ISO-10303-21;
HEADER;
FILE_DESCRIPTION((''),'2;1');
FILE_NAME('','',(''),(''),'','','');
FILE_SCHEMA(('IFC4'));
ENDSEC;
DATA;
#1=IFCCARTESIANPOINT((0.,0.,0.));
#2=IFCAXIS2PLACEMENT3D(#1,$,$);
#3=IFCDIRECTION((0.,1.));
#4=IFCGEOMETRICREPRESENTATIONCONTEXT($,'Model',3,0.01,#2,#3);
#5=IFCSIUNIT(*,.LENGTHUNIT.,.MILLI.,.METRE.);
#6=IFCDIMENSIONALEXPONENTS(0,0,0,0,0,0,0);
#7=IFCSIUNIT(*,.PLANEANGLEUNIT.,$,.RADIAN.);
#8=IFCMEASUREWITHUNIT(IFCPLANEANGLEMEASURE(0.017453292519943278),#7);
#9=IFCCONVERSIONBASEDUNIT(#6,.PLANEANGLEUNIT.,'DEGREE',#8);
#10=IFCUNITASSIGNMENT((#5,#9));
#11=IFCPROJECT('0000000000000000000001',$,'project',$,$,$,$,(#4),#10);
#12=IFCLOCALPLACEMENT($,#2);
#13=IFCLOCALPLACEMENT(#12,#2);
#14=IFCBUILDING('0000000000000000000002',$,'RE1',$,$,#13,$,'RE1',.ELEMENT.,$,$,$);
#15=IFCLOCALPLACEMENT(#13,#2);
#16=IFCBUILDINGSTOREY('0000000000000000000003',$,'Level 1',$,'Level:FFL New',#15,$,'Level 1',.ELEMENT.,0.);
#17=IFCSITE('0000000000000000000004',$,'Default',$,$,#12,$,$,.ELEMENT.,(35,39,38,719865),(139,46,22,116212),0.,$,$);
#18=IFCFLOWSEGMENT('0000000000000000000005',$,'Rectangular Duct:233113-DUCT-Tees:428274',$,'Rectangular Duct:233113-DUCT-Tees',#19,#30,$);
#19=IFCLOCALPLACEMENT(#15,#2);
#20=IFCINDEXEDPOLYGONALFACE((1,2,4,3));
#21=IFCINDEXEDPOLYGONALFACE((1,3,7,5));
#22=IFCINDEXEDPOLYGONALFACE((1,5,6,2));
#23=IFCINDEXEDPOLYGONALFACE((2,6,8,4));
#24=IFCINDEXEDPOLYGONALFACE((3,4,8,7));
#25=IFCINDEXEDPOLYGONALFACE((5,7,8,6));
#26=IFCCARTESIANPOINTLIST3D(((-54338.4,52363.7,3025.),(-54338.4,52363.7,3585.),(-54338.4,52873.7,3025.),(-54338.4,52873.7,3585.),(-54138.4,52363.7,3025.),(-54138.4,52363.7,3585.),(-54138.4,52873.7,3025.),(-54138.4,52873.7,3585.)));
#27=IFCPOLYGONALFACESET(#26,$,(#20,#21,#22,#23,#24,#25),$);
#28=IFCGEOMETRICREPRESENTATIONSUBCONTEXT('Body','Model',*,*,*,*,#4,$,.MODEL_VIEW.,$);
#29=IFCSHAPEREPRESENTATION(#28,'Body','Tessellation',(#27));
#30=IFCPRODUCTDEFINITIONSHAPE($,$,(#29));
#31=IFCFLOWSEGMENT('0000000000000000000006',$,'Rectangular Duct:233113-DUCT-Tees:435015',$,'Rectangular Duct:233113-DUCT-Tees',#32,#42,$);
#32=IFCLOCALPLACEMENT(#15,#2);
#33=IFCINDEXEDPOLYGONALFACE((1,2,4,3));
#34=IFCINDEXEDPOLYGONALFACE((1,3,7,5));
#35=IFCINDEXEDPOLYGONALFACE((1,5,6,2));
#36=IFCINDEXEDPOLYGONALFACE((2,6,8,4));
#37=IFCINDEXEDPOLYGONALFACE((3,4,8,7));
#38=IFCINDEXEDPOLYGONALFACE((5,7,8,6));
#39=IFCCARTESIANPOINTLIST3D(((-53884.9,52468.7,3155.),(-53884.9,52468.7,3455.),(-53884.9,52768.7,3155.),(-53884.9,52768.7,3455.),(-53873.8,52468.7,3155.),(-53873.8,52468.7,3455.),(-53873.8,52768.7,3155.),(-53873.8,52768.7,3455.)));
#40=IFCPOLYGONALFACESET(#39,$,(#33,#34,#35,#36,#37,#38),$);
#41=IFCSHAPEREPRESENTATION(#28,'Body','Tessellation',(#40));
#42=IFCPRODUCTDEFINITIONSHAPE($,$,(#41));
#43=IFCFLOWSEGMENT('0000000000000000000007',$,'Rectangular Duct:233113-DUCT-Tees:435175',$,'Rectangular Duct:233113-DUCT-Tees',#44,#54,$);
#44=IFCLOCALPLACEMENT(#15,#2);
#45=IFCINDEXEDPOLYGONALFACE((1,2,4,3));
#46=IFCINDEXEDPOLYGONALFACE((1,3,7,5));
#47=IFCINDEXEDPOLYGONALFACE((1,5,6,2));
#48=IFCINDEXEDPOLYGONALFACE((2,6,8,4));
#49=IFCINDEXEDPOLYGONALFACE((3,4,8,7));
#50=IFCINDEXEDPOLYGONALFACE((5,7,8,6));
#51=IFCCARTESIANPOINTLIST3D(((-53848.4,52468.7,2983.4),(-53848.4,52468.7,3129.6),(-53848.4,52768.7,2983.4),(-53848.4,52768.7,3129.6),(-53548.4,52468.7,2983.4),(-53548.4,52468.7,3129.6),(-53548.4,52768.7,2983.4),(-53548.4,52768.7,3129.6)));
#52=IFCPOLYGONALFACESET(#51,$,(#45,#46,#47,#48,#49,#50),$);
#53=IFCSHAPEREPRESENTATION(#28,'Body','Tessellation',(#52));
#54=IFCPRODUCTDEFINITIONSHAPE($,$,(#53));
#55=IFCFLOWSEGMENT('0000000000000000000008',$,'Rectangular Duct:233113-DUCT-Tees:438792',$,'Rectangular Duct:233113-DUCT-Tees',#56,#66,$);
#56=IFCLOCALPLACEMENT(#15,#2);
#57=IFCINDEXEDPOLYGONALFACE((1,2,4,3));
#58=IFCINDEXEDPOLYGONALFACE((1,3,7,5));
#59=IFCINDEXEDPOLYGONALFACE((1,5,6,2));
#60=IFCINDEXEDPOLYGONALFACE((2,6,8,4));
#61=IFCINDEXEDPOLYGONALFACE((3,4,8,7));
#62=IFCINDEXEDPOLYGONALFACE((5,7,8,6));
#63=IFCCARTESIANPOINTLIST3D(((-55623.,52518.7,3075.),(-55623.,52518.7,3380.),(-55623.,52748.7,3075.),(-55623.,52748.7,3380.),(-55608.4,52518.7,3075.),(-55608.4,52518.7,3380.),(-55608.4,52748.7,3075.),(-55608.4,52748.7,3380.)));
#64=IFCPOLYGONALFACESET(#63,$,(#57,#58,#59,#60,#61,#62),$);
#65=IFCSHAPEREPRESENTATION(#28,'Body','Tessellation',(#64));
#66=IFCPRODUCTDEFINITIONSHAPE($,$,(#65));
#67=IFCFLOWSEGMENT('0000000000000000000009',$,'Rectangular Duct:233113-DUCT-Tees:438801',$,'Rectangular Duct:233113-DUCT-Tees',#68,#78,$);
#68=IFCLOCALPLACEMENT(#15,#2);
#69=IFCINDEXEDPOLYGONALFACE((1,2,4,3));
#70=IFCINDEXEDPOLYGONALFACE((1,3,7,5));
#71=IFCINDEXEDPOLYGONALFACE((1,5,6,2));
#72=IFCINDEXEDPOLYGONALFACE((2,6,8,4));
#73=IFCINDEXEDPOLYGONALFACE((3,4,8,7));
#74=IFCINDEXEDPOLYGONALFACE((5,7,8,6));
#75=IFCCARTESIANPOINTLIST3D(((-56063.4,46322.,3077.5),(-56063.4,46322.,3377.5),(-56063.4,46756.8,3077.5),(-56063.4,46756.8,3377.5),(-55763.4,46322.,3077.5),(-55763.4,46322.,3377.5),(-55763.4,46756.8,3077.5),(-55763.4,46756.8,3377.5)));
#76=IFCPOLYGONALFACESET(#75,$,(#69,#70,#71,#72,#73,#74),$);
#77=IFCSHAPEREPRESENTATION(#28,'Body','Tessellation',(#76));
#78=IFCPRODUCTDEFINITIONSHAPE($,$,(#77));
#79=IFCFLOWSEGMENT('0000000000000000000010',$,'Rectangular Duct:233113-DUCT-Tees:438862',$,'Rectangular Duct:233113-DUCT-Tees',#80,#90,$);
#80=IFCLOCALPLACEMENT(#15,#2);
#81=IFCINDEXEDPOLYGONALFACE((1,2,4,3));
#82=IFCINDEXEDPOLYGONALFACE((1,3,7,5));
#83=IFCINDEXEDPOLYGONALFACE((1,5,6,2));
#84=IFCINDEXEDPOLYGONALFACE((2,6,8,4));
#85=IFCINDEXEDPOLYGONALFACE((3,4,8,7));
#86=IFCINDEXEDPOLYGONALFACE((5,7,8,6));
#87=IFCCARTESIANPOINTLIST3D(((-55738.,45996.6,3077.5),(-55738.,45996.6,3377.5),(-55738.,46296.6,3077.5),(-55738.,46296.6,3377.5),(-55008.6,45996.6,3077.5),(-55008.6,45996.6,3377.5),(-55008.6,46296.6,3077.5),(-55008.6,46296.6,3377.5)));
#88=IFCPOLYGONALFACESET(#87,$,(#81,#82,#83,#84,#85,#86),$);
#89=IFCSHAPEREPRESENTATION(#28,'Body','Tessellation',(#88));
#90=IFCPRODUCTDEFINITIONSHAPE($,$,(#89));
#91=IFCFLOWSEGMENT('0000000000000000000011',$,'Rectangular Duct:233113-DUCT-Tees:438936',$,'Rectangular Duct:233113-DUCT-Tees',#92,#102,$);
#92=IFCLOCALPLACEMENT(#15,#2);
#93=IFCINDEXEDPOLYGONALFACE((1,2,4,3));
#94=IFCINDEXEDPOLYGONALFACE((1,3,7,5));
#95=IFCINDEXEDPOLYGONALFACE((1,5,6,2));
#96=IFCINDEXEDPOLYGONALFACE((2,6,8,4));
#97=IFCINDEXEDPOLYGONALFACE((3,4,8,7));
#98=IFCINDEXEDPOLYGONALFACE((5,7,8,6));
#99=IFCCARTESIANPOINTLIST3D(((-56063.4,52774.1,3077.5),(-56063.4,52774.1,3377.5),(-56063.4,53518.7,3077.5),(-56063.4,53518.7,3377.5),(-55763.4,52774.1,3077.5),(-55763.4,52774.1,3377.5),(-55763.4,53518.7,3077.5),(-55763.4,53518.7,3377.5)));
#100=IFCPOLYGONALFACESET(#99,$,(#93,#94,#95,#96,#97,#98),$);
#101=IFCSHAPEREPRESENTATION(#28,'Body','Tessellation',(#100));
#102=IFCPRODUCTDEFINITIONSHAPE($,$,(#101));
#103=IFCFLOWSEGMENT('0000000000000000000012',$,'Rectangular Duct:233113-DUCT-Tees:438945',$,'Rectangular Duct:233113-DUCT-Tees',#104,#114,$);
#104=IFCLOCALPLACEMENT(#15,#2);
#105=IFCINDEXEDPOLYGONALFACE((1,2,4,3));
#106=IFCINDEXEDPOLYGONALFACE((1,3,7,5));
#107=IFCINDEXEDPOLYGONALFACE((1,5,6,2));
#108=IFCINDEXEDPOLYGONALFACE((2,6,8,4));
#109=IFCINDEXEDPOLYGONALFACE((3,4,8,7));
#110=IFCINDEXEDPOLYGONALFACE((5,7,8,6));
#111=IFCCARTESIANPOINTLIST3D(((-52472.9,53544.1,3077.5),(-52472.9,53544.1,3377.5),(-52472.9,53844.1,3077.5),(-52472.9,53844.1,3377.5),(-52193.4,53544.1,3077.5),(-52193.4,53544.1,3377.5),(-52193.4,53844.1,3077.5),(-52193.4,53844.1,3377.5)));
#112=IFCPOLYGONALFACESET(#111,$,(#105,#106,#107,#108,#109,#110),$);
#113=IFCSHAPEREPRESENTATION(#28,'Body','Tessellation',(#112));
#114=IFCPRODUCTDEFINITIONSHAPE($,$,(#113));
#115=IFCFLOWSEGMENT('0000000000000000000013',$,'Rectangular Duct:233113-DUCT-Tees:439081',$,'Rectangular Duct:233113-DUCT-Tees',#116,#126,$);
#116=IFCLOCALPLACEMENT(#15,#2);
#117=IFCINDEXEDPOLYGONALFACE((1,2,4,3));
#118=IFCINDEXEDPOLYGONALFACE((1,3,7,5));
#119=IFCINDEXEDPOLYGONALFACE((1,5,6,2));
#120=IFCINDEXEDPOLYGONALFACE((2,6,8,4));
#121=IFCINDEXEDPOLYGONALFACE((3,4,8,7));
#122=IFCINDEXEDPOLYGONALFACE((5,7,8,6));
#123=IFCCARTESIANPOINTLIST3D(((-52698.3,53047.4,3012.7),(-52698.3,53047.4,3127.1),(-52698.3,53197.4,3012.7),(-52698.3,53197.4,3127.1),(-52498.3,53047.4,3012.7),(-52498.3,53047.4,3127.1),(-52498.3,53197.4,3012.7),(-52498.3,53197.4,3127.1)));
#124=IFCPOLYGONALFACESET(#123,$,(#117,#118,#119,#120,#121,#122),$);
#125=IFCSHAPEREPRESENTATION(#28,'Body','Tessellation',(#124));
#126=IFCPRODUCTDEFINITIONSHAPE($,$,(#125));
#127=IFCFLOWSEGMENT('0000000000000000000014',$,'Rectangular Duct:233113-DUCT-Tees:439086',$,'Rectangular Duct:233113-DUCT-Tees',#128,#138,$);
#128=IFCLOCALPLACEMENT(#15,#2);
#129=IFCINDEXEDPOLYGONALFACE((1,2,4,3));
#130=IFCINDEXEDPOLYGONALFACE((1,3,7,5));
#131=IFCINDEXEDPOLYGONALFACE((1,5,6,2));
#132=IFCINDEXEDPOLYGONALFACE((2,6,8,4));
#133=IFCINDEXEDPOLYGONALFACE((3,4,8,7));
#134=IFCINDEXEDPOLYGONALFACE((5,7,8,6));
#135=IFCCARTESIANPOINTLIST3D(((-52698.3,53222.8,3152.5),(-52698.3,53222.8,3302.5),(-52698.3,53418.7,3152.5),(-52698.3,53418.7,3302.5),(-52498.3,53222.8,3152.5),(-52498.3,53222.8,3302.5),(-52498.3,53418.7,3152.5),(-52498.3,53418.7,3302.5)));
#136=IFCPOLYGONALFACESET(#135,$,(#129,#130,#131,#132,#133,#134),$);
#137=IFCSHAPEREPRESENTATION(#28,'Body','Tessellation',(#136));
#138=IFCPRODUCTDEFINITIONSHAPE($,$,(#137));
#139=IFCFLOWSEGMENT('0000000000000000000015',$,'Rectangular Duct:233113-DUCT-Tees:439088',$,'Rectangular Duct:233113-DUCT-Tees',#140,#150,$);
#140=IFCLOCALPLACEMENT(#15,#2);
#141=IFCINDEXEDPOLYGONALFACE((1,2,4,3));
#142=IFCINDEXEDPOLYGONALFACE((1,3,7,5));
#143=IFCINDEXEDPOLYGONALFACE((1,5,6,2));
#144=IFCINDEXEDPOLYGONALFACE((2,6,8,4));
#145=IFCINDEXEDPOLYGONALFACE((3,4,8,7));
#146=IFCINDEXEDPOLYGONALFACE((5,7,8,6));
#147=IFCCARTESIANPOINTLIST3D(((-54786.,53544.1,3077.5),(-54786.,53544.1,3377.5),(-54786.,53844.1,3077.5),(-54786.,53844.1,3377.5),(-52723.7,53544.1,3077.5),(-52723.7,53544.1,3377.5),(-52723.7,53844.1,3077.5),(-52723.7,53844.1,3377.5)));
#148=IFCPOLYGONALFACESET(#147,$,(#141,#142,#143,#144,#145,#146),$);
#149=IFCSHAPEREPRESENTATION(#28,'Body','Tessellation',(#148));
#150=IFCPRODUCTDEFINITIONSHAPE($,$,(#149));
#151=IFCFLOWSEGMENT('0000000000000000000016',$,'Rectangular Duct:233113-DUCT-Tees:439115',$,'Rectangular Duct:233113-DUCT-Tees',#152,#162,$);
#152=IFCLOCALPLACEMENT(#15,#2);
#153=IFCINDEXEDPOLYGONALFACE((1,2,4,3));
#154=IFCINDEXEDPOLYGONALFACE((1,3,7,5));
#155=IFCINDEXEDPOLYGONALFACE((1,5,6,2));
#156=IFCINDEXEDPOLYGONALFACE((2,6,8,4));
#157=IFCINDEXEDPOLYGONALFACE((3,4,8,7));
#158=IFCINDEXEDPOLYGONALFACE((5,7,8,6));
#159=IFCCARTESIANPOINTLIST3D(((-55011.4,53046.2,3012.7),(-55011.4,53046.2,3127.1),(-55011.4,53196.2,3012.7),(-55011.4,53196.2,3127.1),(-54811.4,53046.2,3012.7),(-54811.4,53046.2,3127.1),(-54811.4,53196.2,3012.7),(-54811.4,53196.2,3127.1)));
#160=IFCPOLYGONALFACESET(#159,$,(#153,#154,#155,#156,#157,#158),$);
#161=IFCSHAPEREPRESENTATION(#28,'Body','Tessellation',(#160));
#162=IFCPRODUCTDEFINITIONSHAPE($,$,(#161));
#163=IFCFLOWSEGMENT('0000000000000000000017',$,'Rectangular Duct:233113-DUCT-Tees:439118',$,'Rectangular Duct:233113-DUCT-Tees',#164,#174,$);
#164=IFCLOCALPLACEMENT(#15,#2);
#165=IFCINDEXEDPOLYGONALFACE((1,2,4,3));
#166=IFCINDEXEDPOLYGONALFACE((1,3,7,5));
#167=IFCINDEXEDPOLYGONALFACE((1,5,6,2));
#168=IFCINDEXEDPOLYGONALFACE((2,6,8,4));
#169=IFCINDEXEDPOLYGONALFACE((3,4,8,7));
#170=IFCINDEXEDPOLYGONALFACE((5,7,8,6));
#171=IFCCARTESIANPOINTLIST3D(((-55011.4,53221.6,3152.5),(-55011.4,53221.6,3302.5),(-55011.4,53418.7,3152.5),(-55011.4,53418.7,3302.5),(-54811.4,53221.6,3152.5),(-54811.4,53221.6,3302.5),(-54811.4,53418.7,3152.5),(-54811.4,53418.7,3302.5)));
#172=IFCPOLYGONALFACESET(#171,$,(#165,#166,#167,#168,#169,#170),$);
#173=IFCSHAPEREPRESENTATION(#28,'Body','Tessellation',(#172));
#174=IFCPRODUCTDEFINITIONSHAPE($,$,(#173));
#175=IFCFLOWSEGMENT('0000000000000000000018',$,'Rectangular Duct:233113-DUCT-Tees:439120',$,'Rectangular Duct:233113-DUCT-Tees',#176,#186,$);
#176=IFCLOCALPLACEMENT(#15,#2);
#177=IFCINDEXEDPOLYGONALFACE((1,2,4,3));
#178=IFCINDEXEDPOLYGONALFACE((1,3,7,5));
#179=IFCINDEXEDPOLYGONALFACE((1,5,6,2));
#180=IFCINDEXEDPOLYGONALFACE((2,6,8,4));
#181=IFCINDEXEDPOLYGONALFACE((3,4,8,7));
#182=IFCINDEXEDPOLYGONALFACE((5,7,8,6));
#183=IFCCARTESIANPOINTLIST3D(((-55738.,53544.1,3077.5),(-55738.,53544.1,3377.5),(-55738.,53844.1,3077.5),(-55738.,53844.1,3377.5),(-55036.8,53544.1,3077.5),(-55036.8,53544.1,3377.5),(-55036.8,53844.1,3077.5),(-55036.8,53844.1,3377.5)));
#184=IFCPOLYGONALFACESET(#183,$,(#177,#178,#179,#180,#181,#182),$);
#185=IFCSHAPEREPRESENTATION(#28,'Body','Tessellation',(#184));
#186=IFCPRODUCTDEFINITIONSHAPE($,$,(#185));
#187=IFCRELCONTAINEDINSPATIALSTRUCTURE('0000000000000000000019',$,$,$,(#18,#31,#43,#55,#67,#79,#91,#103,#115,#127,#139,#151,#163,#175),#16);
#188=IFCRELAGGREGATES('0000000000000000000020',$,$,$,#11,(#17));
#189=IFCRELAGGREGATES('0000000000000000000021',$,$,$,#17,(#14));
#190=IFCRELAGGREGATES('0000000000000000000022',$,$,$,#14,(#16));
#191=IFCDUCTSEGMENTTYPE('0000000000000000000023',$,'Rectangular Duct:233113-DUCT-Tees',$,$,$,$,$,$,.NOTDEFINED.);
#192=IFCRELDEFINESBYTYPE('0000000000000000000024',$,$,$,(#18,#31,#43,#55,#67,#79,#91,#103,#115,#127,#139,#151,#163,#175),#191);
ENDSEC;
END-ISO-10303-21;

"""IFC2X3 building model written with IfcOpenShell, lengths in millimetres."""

from ifc_helpers import new_model, entity, si_unit, converted_unit, direction, frame, frame_2d, origin, origin_2d_with_axis, place, context, subcontext, project, spatial, rectangle, extrude, type_object, element, save


model = new_model("IFC2X3")

# Units and contexts
model_context = context("Model", 3, precision=0.01, world=origin(), true_north=direction((0.0, 1.0)))
body_context = subcontext(model_context, "Body", "Model", "MODEL_VIEW")
ifc_project = project(units=[si_unit("LENGTHUNIT", "METRE", prefix="MILLI"), converted_unit("PLANEANGLEUNIT", "DEGREE", entity("IfcPlaneAngleMeasure", 0.017453292519943278), si_unit("PLANEANGLEUNIT", "RADIAN"), dimensions=[0, 0, 0, 0, 0, 0, 0])], contexts=[model_context])

# Site, building, storey
site_placement = place(None, origin())
site = spatial("IfcSite", under=ifc_project, at=site_placement, Name="Default", CompositionType="ELEMENT", RefLatitude=(35, 39, 38, 719865), RefLongitude=(139, 46, 22, 116212), RefElevation=0.0)
building_placement = place(site_placement, origin())
building = spatial("IfcBuilding", under=site, at=building_placement, Name="RE1", LongName="RE1", CompositionType="ELEMENT")
storey_placement = place(building_placement, origin())
storey = spatial("IfcBuildingStorey", under=building, at=storey_placement, Name="Level 1", ObjectType="Level:FFL New", LongName="Level 1", CompositionType="ELEMENT", Elevation=0.0)

# Flow segments
duct_segment_type = type_object("IfcDuctSegmentType", Name="Rectangular Duct:233113-DUCT-Tees", PredefinedType="NOTDEFINED")
flow_segment_1_placement = place(storey_placement, origin())
element("IfcFlowSegment", 1, at=flow_segment_1_placement, inside=storey, type_object=duct_segment_type, Name="Rectangular Duct:233113-DUCT-Tees:428274", ObjectType="Rectangular Duct:233113-DUCT-Tees", context=body_context, shape_type="SweptSolid", body=[
    extrude(rectangle(XDim=200.0, YDim=510.0, at=origin_2d_with_axis()), frame((-54238.4, 52618.7, 3025.0)), (0.0, 0.0, 1.0), 560.0),
])
flow_segment_2_placement = place(storey_placement, origin())
element("IfcFlowSegment", 2, at=flow_segment_2_placement, inside=storey, type_object=duct_segment_type, Name="Rectangular Duct:233113-DUCT-Tees:435015", ObjectType="Rectangular Duct:233113-DUCT-Tees", context=body_context, shape_type="SweptSolid", body=[
    extrude(rectangle(XDim=11.1, YDim=300.0, at=frame_2d((0.0, 0.0), x_axis=(1.0, 0.0))), frame((-53879.4, 52618.7, 3155.0)), (0.0, 0.0, 1.0), 300.0),
])
flow_segment_3_placement = place(storey_placement, origin())
element("IfcFlowSegment", 3, at=flow_segment_3_placement, inside=storey, type_object=duct_segment_type, Name="Rectangular Duct:233113-DUCT-Tees:435175", ObjectType="Rectangular Duct:233113-DUCT-Tees", context=body_context, shape_type="SweptSolid", body=[
    extrude(rectangle(XDim=300.0, YDim=300.0, at=origin_2d_with_axis()), frame((-53698.4, 52618.7, 2983.4), z_axis=(0.0, 0.0, 1.0), x_axis=(0.0, 1.0, 0.0)), (0.0, 0.0, 1.0), 146.2),
])
flow_segment_4_placement = place(storey_placement, origin())
element("IfcFlowSegment", 4, at=flow_segment_4_placement, inside=storey, type_object=duct_segment_type, Name="Rectangular Duct:233113-DUCT-Tees:438792", ObjectType="Rectangular Duct:233113-DUCT-Tees", context=body_context, shape_type="SweptSolid", body=[
    extrude(rectangle(XDim=14.6, YDim=230.0, at=frame_2d((0.0, 0.0), x_axis=(1.0, 0.0))), frame((-55615.7, 52633.7, 3075.0), z_axis=(0.0, 0.0, 1.0), x_axis=(-1.0, 0.0, 0.0)), (0.0, 0.0, 1.0), 305.0),
])
flow_segment_5_placement = place(storey_placement, origin())
element("IfcFlowSegment", 5, at=flow_segment_5_placement, inside=storey, type_object=duct_segment_type, Name="Rectangular Duct:233113-DUCT-Tees:438801", ObjectType="Rectangular Duct:233113-DUCT-Tees", context=body_context, shape_type="SweptSolid", body=[
    extrude(rectangle(XDim=434.8, YDim=300.0, at=frame_2d((0.0, 0.0), x_axis=(1.0, 0.0))), frame((-55913.4, 46539.4, 3077.5), z_axis=(0.0, 0.0, 1.0), x_axis=(0.0, -1.0, 0.0)), (0.0, 0.0, 1.0), 300.0),
])
flow_segment_6_placement = place(storey_placement, origin())
element("IfcFlowSegment", 6, at=flow_segment_6_placement, inside=storey, type_object=duct_segment_type, Name="Rectangular Duct:233113-DUCT-Tees:438862", ObjectType="Rectangular Duct:233113-DUCT-Tees", context=body_context, shape_type="SweptSolid", body=[
    extrude(rectangle(XDim=729.5, YDim=300.0, at=frame_2d((0.0, 0.0), x_axis=(1.0, 0.0))), frame((-55373.3, 46146.6, 3077.5)), (0.0, 0.0, 1.0), 300.0),
])
flow_segment_7_placement = place(storey_placement, origin())
element("IfcFlowSegment", 7, at=flow_segment_7_placement, inside=storey, type_object=duct_segment_type, Name="Rectangular Duct:233113-DUCT-Tees:438936", ObjectType="Rectangular Duct:233113-DUCT-Tees", context=body_context, shape_type="SweptSolid", body=[
    extrude(rectangle(XDim=744.6, YDim=300.0, at=frame_2d((0.0, 0.0), x_axis=(1.0, 0.0))), frame((-55913.4, 53146.4, 3077.5), z_axis=(0.0, 0.0, 1.0), x_axis=(0.0, 1.0, 0.0)), (0.0, 0.0, 1.0), 300.0),
])
flow_segment_8_placement = place(storey_placement, origin())
element("IfcFlowSegment", 8, at=flow_segment_8_placement, inside=storey, type_object=duct_segment_type, Name="Rectangular Duct:233113-DUCT-Tees:438945", ObjectType="Rectangular Duct:233113-DUCT-Tees", context=body_context, shape_type="SweptSolid", body=[
    extrude(rectangle(XDim=279.5, YDim=300.0, at=frame_2d((0.0, 0.0), x_axis=(1.0, 0.0))), frame((-52333.2, 53694.1, 3077.5)), (0.0, 0.0, 1.0), 300.0),
])
flow_segment_9_placement = place(storey_placement, origin())
element("IfcFlowSegment", 9, at=flow_segment_9_placement, inside=storey, type_object=duct_segment_type, Name="Rectangular Duct:233113-DUCT-Tees:439081", ObjectType="Rectangular Duct:233113-DUCT-Tees", context=body_context, shape_type="SweptSolid", body=[
    extrude(rectangle(XDim=150.0, YDim=200.0, at=origin_2d_with_axis()), frame((-52598.3, 53122.4, 3012.7), z_axis=(0.0, 0.0, 1.0), x_axis=(0.0, 1.0, 0.0)), (0.0, 0.0, 1.0), 114.4),
])
flow_segment_10_placement = place(storey_placement, origin())
element("IfcFlowSegment", 10, at=flow_segment_10_placement, inside=storey, type_object=duct_segment_type, Name="Rectangular Duct:233113-DUCT-Tees:439086", ObjectType="Rectangular Duct:233113-DUCT-Tees", context=body_context, shape_type="SweptSolid", body=[
    extrude(rectangle(XDim=195.9, YDim=200.0, at=frame_2d((0.0, 0.0), x_axis=(1.0, 0.0))), frame((-52598.3, 53320.8, 3152.5), z_axis=(0.0, 0.0, 1.0), x_axis=(0.0, -1.0, 0.0)), (0.0, 0.0, 1.0), 150.0),
])
flow_segment_11_placement = place(storey_placement, origin())
element("IfcFlowSegment", 11, at=flow_segment_11_placement, inside=storey, type_object=duct_segment_type, Name="Rectangular Duct:233113-DUCT-Tees:439088", ObjectType="Rectangular Duct:233113-DUCT-Tees", context=body_context, shape_type="SweptSolid", body=[
    extrude(rectangle(XDim=2062.3, YDim=300.0, at=frame_2d((0.0, 0.0), x_axis=(1.0, 0.0))), frame((-53754.8, 53694.1, 3077.5)), (0.0, 0.0, 1.0), 300.0),
])
flow_segment_12_placement = place(storey_placement, origin())
element("IfcFlowSegment", 12, at=flow_segment_12_placement, inside=storey, type_object=duct_segment_type, Name="Rectangular Duct:233113-DUCT-Tees:439115", ObjectType="Rectangular Duct:233113-DUCT-Tees", context=body_context, shape_type="SweptSolid", body=[
    extrude(rectangle(XDim=150.0, YDim=200.0, at=origin_2d_with_axis()), frame((-54911.4, 53121.2, 3012.7), z_axis=(0.0, 0.0, 1.0), x_axis=(0.0, -1.0, 0.0)), (0.0, 0.0, 1.0), 114.4),
])
flow_segment_13_placement = place(storey_placement, origin())
element("IfcFlowSegment", 13, at=flow_segment_13_placement, inside=storey, type_object=duct_segment_type, Name="Rectangular Duct:233113-DUCT-Tees:439118", ObjectType="Rectangular Duct:233113-DUCT-Tees", context=body_context, shape_type="SweptSolid", body=[
    extrude(rectangle(XDim=197.1, YDim=200.0, at=frame_2d((0.0, 0.0), x_axis=(1.0, 0.0))), frame((-54911.4, 53320.2, 3152.5), z_axis=(0.0, 0.0, 1.0), x_axis=(0.0, -1.0, 0.0)), (0.0, 0.0, 1.0), 150.0),
])
flow_segment_14_placement = place(storey_placement, origin())
element("IfcFlowSegment", 14, at=flow_segment_14_placement, inside=storey, type_object=duct_segment_type, Name="Rectangular Duct:233113-DUCT-Tees:439120", ObjectType="Rectangular Duct:233113-DUCT-Tees", context=body_context, shape_type="SweptSolid", body=[
    extrude(rectangle(XDim=701.2, YDim=300.0, at=frame_2d((0.0, 0.0), x_axis=(1.0, 0.0))), frame((-55387.4, 53694.1, 3077.5)), (0.0, 0.0, 1.0), 300.0),
])

save(model, "model.ifc")
